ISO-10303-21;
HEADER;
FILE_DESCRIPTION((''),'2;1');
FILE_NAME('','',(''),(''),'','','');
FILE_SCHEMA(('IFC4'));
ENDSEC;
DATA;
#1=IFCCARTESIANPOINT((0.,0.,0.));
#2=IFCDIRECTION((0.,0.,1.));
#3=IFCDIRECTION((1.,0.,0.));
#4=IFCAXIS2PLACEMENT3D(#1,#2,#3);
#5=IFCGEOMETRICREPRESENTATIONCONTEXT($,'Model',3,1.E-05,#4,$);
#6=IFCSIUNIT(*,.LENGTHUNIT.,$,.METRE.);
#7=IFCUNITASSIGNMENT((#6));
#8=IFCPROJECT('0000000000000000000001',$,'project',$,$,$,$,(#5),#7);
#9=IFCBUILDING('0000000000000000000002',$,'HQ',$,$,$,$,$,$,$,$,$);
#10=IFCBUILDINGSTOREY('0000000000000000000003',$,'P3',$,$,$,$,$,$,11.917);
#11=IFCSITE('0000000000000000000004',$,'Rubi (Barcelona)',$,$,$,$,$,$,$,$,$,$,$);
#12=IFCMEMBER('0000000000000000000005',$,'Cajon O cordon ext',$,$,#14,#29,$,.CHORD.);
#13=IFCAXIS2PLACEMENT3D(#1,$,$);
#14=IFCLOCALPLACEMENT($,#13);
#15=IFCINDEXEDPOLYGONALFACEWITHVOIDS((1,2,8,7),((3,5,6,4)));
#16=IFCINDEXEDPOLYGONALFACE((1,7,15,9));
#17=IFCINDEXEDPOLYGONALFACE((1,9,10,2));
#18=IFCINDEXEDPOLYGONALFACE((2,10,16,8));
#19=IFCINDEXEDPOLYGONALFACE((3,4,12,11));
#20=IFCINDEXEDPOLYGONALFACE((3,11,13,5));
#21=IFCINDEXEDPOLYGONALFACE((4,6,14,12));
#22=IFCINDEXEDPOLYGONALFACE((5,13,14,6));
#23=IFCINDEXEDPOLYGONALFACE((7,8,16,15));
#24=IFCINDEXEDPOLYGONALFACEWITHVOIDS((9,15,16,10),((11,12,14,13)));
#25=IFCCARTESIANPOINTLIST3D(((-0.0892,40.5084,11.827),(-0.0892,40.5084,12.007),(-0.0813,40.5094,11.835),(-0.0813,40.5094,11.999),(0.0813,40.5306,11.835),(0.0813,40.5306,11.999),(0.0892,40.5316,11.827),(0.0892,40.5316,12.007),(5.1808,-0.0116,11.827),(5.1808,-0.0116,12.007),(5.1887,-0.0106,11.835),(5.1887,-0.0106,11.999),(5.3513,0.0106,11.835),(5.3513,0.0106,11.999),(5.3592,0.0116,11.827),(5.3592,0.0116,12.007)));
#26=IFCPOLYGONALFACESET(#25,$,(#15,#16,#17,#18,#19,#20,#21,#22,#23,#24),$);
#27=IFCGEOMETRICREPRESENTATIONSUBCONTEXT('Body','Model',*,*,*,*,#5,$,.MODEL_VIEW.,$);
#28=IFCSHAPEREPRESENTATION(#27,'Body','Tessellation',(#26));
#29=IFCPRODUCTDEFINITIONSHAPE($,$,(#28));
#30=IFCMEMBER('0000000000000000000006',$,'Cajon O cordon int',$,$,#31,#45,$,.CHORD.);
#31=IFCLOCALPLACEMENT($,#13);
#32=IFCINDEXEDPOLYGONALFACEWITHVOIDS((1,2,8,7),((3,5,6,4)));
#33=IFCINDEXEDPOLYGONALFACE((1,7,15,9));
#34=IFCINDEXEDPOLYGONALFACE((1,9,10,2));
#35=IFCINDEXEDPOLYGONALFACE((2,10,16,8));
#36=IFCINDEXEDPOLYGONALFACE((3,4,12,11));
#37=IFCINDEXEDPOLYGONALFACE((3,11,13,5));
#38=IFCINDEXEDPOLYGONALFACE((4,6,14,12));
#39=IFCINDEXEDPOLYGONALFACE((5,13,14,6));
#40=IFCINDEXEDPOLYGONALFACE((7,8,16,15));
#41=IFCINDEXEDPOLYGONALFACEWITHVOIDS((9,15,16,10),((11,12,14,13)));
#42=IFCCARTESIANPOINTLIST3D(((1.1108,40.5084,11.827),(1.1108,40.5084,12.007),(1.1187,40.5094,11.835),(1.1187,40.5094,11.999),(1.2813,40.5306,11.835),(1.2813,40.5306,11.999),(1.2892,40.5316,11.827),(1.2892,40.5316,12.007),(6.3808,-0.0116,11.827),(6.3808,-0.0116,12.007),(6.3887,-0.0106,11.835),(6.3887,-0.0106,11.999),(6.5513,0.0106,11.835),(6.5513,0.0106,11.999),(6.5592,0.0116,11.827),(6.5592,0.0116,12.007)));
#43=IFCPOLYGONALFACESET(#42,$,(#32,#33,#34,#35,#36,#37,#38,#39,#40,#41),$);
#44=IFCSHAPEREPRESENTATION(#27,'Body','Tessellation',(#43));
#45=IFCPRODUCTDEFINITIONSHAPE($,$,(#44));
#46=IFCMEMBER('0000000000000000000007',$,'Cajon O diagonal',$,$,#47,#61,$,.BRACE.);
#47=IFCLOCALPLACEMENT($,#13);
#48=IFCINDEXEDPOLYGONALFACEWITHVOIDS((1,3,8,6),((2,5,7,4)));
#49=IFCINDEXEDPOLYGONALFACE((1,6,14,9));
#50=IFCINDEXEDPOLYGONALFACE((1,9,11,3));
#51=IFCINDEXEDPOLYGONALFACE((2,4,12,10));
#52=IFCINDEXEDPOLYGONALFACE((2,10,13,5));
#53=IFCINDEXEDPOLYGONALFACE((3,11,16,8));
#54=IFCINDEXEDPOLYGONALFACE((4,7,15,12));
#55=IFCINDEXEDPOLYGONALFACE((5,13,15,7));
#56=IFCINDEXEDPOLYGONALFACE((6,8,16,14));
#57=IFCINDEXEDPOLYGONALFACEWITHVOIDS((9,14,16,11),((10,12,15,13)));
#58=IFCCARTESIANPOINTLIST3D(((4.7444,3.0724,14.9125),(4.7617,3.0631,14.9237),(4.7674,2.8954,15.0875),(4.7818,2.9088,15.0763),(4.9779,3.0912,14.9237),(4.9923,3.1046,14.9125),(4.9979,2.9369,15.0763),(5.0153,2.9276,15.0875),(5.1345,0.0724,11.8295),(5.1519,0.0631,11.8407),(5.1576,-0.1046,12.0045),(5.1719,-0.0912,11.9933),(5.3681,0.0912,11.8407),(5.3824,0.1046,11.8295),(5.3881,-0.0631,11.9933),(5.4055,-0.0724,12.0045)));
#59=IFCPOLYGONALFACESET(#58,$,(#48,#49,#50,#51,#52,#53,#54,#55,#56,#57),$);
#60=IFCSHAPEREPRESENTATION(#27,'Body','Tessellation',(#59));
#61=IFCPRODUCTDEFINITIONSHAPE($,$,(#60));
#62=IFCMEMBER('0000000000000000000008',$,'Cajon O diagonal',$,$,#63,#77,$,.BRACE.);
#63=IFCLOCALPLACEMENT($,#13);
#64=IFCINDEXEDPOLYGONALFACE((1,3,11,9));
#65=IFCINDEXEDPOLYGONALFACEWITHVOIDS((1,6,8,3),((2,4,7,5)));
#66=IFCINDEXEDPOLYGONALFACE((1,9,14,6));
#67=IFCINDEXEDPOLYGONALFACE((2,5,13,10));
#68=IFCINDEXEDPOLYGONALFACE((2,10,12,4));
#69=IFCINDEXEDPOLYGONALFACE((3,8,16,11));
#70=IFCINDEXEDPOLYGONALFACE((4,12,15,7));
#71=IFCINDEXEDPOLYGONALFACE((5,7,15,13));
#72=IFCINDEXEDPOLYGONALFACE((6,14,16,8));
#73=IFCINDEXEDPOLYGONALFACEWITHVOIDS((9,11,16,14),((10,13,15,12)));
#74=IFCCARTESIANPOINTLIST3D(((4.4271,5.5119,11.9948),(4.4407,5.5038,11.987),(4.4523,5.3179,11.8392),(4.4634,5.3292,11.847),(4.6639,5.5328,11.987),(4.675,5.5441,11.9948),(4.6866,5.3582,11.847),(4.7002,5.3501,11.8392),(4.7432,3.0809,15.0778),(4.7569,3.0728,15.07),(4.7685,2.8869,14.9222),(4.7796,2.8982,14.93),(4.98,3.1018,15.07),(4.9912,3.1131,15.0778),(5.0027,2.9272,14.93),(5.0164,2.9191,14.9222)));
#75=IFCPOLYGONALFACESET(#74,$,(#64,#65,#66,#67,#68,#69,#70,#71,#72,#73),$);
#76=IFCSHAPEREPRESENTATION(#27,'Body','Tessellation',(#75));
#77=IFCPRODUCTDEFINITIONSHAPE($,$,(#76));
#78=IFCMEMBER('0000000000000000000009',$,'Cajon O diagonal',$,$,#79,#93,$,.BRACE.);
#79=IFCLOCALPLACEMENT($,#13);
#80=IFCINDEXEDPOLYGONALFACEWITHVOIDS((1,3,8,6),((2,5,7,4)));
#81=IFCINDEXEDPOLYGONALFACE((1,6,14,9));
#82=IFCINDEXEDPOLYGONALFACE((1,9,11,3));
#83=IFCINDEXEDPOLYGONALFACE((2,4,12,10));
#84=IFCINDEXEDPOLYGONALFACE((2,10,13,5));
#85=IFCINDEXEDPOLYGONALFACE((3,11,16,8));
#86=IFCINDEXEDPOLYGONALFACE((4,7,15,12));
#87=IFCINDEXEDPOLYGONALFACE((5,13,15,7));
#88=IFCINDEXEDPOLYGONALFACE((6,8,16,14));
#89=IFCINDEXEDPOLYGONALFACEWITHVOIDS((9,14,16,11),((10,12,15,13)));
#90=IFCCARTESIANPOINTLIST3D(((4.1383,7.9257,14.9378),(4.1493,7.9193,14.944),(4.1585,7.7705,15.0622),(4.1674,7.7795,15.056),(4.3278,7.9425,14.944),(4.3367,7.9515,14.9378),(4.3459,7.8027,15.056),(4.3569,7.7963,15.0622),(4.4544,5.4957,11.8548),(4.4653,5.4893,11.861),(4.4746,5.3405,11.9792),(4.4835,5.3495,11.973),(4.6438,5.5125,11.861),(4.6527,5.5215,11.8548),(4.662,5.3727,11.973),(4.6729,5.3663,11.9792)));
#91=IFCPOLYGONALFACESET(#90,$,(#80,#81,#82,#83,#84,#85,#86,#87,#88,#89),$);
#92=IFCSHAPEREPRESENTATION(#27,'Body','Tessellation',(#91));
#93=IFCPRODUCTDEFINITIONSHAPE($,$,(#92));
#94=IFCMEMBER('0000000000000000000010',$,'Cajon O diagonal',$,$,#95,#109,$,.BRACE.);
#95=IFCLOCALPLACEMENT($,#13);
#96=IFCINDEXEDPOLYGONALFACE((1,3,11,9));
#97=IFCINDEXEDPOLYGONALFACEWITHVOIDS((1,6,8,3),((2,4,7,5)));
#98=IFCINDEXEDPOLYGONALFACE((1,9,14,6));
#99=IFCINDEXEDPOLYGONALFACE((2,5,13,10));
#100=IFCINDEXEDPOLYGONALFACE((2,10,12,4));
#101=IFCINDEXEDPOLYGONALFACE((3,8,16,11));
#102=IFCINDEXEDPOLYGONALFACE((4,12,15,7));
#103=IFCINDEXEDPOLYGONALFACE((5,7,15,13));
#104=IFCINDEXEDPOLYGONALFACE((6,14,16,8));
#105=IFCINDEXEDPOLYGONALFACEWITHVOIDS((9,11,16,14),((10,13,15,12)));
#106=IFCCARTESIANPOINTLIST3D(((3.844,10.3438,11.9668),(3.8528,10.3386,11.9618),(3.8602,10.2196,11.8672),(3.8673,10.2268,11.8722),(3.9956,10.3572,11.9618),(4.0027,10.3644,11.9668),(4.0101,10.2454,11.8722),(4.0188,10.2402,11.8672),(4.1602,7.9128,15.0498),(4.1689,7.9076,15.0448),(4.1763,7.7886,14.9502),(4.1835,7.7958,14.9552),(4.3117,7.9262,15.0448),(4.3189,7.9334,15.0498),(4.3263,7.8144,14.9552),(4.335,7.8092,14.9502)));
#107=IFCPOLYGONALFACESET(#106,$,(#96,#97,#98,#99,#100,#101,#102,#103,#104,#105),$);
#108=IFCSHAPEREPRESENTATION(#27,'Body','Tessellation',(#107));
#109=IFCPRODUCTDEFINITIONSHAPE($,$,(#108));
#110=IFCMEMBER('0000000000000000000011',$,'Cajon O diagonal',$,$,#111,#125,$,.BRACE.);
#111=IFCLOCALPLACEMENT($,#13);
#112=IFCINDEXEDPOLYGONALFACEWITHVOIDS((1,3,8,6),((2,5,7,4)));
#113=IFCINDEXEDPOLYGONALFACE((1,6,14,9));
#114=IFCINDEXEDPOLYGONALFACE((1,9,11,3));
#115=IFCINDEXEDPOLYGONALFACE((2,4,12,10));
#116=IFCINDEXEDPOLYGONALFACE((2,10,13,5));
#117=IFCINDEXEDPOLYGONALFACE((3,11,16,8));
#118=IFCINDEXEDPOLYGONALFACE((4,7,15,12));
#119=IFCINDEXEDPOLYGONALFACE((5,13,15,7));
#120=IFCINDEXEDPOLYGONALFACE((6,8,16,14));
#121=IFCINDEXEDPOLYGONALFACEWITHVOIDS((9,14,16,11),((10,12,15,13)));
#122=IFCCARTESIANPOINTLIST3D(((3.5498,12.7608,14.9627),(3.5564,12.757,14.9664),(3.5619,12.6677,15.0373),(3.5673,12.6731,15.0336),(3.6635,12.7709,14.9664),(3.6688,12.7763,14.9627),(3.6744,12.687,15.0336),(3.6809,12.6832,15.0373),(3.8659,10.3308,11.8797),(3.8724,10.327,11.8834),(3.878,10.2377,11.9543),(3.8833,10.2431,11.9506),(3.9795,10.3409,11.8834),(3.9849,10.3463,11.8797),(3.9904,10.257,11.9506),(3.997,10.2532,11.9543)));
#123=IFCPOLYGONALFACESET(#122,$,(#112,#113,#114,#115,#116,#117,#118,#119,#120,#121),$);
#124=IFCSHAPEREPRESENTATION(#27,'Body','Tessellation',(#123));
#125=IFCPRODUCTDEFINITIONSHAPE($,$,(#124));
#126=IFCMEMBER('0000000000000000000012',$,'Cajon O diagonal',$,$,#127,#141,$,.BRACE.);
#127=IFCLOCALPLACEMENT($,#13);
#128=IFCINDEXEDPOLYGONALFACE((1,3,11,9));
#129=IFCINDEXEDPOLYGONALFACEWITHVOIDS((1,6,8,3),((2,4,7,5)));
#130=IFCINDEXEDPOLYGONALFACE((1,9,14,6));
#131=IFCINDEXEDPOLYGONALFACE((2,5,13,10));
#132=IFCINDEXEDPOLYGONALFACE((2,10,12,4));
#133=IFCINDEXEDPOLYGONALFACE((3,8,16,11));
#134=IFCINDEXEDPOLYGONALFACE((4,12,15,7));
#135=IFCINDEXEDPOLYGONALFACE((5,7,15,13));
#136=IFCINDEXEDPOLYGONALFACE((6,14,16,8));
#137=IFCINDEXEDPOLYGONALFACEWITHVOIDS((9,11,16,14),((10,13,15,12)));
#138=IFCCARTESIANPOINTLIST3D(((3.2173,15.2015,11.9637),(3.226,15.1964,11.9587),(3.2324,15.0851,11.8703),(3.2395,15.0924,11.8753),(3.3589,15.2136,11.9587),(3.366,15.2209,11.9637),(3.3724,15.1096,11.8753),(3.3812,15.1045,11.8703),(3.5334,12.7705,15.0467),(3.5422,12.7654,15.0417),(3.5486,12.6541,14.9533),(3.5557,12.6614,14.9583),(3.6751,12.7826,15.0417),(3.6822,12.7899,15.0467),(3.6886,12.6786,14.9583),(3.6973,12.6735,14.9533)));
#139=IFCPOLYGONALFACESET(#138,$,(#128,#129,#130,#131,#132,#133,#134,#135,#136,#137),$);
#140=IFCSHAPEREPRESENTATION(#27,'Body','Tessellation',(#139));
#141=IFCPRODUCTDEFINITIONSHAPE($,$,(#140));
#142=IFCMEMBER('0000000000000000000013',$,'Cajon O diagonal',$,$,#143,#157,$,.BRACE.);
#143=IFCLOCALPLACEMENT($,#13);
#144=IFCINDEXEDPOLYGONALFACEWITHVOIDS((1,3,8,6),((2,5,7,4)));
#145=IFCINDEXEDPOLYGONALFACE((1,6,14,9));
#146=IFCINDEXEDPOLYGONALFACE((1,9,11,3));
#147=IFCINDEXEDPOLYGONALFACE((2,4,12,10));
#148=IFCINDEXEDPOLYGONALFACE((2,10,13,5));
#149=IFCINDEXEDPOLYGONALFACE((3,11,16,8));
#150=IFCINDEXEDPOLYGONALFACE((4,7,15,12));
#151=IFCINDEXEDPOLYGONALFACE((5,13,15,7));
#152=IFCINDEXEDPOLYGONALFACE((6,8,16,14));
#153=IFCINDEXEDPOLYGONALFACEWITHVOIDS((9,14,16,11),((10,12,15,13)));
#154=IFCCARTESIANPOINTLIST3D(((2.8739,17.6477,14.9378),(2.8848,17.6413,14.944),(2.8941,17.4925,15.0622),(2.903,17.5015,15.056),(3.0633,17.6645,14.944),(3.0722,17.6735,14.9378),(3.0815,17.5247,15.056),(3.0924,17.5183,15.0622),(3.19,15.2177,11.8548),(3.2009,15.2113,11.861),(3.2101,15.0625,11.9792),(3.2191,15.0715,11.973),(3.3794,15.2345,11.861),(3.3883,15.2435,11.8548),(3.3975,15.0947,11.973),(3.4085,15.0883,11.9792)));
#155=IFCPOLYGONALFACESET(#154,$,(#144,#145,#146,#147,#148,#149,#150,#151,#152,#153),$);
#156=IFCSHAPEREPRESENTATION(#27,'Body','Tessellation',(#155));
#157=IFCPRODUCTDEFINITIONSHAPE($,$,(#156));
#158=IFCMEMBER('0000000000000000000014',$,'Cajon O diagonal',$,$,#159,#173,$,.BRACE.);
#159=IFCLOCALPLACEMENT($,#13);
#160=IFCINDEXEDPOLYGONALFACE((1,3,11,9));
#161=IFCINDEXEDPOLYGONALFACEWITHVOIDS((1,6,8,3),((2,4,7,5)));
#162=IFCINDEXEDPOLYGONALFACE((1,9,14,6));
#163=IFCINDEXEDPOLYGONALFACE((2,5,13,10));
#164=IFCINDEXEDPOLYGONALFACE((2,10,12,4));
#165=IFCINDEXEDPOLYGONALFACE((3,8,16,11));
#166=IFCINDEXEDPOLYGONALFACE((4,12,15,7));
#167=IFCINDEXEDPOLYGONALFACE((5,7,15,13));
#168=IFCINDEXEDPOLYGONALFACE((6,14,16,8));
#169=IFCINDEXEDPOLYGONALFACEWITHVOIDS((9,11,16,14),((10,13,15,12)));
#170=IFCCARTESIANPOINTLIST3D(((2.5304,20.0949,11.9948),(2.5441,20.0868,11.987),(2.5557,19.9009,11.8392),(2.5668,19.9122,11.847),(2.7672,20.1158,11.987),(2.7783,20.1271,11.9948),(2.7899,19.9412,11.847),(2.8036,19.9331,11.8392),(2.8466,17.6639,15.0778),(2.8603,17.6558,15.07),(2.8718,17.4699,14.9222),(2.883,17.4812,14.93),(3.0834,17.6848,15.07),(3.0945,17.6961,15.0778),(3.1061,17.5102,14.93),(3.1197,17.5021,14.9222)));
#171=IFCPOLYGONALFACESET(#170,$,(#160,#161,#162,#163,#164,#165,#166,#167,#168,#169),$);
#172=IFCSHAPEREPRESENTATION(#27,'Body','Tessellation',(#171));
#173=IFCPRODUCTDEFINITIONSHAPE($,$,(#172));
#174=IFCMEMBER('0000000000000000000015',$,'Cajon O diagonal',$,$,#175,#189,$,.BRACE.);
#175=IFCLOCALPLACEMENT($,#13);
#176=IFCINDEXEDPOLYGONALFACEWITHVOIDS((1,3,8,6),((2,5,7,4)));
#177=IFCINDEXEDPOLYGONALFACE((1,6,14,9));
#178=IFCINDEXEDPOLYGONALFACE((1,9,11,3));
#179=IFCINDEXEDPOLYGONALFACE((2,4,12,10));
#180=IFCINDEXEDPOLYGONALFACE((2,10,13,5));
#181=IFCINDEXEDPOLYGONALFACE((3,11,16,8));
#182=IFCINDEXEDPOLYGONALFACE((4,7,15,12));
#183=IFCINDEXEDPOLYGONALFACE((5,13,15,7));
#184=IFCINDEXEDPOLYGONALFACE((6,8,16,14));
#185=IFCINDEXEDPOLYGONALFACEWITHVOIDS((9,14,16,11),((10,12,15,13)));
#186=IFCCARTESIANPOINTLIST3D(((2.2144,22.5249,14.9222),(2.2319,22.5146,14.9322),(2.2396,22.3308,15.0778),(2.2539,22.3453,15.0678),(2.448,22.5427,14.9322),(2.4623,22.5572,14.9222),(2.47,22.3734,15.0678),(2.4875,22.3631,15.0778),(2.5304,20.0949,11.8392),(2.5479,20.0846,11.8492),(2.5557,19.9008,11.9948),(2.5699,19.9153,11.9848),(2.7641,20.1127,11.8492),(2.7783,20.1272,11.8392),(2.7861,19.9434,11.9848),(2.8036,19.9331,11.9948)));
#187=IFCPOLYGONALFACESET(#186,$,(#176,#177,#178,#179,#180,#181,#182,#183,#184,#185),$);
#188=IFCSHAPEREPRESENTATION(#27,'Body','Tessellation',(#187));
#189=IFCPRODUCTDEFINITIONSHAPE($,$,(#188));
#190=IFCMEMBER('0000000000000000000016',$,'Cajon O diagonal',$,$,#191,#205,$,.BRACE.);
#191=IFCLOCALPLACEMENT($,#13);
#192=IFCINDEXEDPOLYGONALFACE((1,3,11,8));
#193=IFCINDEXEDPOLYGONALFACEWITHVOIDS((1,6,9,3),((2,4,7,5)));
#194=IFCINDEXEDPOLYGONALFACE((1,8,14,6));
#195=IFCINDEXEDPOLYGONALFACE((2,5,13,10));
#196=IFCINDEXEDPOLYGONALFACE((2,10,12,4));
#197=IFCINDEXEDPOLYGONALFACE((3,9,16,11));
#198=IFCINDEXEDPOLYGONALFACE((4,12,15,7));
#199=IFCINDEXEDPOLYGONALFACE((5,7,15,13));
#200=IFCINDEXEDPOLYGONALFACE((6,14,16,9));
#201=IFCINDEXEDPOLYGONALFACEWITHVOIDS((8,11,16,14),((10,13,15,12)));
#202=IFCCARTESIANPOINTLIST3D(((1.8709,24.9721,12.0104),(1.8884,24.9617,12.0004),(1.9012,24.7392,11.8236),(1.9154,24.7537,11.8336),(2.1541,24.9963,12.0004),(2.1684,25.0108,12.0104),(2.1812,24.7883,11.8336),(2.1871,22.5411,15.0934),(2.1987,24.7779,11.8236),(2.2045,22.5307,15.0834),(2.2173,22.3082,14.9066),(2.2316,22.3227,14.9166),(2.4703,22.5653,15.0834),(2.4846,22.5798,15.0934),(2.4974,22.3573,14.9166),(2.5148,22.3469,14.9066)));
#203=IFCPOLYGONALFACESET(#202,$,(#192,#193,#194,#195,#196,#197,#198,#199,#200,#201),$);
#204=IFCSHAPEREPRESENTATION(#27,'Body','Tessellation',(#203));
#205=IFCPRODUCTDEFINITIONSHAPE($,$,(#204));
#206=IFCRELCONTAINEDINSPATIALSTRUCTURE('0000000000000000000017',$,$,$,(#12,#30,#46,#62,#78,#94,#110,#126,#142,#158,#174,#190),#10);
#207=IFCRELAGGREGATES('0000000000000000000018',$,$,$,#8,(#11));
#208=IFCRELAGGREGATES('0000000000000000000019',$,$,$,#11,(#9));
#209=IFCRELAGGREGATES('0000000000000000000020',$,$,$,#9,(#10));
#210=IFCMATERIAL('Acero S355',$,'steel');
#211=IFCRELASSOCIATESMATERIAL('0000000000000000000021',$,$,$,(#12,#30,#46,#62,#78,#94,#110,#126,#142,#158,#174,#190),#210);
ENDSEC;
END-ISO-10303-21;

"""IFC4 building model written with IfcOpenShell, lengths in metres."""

from ifc_helpers import new_model, si_unit, frame, origin_with_axes, place, context, subcontext, project, spatial, hollow_rectangle, extrude, material, element, save


model = new_model("IFC4")

# Units and contexts
model_context = context("Model", 3, precision=1e-05, world=origin_with_axes())
body_context = subcontext(model_context, "Body", "Model", "MODEL_VIEW")
ifc_project = project(units=[si_unit("LENGTHUNIT", "METRE")], contexts=[model_context])

# Site, building, storey
site = spatial("IfcSite", under=ifc_project, Name="Rubi (Barcelona)")
building = spatial("IfcBuilding", under=site, Name="HQ")
storey = spatial("IfcBuildingStorey", under=building, Name="P3", Elevation=11.917)

# Members
ifc_material = material(Name="Acero S355", Category="steel")
member_1_placement = place(None, origin_with_axes())
element("IfcMember", 1, at=member_1_placement, inside=storey, material=ifc_material, Name="Cajon O cordon ext", PredefinedType="CHORD", context=body_context, shape_type="SweptSolid", body=[
    extrude(hollow_rectangle(XDim=0.18, YDim=0.18, WallThickness=0.008), frame((5.27, 0.0, 11.917), z_axis=(-0.128973, 0.991648, 0.0), x_axis=(-0.991648, -0.128973, 0.0)), (0.0, 0.0, 1.0), 40.8613),
])
member_2_placement = place(None, origin_with_axes())
element("IfcMember", 2, at=member_2_placement, inside=storey, material=ifc_material, Name="Cajon O cordon int", PredefinedType="CHORD", context=body_context, shape_type="SweptSolid", body=[
    extrude(hollow_rectangle(XDim=0.18, YDim=0.18, WallThickness=0.008), frame((6.47, 0.0, 11.917), z_axis=(-0.128973, 0.991648, 0.0), x_axis=(-0.991648, -0.128973, 0.0)), (0.0, 0.0, 1.0), 40.8613),
])
member_3_placement = place(None, origin_with_axes())
element("IfcMember", 3, at=member_3_placement, inside=storey, material=ifc_material, Name="Cajon O diagonal", PredefinedType="BRACE", context=body_context, shape_type="SweptSolid", body=[
    extrude(hollow_rectangle(XDim=0.25, YDim=0.25, WallThickness=0.016), frame((5.27, 0.0, 11.917), z_axis=(-0.090332, 0.694543, 0.713758), x_axis=(-0.991648, -0.128973, 0.0)), (0.0, 0.0, 1.0), 4.3194),
])
member_4_placement = place(None, origin_with_axes())
element("IfcMember", 4, at=member_4_placement, inside=storey, material=ifc_material, Name="Cajon O diagonal", PredefinedType="BRACE", context=body_context, shape_type="SweptSolid", body=[
    extrude(hollow_rectangle(XDim=0.25, YDim=0.25, WallThickness=0.0125), frame((4.5636, 5.431, 11.917), z_axis=(0.08027, -0.617184, 0.782714), x_axis=(0.991648, 0.128973, 0.0)), (0.0, 0.0, 1.0), 3.9389),
])
member_5_placement = place(None, origin_with_axes())
element("IfcMember", 5, at=member_5_placement, inside=storey, material=ifc_material, Name="Cajon O diagonal", PredefinedType="BRACE", context=body_context, shape_type="SweptSolid", body=[
    extrude(hollow_rectangle(XDim=0.2, YDim=0.2, WallThickness=0.01), frame((4.5636, 5.431, 11.917), z_axis=(-0.08025, 0.617028, 0.782839), x_axis=(-0.991648, -0.128973, 0.0)), (0.0, 0.0, 1.0), 3.9382),
])
member_6_placement = place(None, origin_with_axes())
element("IfcMember", 6, at=member_6_placement, inside=storey, material=ifc_material, Name="Cajon O diagonal", PredefinedType="BRACE", context=body_context, shape_type="SweptSolid", body=[
    extrude(hollow_rectangle(XDim=0.16, YDim=0.16, WallThickness=0.008), frame((3.9314, 10.292, 11.917), z_axis=(0.08027, -0.617184, 0.782714), x_axis=(0.991648, 0.128973, 0.0)), (0.0, 0.0, 1.0), 3.9389),
])
member_7_placement = place(None, origin_with_axes())
element("IfcMember", 7, at=member_7_placement, inside=storey, material=ifc_material, Name="Cajon O diagonal", PredefinedType="BRACE", context=body_context, shape_type="SweptSolid", body=[
    extrude(hollow_rectangle(XDim=0.12, YDim=0.12, WallThickness=0.006), frame((3.9314, 10.292, 11.917), z_axis=(-0.08025, 0.617028, 0.782839), x_axis=(-0.991648, -0.128973, 0.0)), (0.0, 0.0, 1.0), 3.9382),
])
member_8_placement = place(None, origin_with_axes())
element("IfcMember", 8, at=member_8_placement, inside=storey, material=ifc_material, Name="Cajon O diagonal", PredefinedType="BRACE", context=body_context, shape_type="SweptSolid", body=[
    extrude(hollow_rectangle(XDim=0.15, YDim=0.15, WallThickness=0.008), frame((3.2992, 15.153, 11.917), z_axis=(0.08027, -0.617184, 0.782714), x_axis=(0.991648, 0.128973, 0.0)), (0.0, 0.0, 1.0), 3.9389),
])
member_9_placement = place(None, origin_with_axes())
element("IfcMember", 9, at=member_9_placement, inside=storey, material=ifc_material, Name="Cajon O diagonal", PredefinedType="BRACE", context=body_context, shape_type="SweptSolid", body=[
    extrude(hollow_rectangle(XDim=0.2, YDim=0.2, WallThickness=0.01), frame((3.2992, 15.153, 11.917), z_axis=(-0.08025, 0.617028, 0.782839), x_axis=(-0.991648, -0.128973, 0.0)), (0.0, 0.0, 1.0), 3.9382),
])
member_10_placement = place(None, origin_with_axes())
element("IfcMember", 10, at=member_10_placement, inside=storey, material=ifc_material, Name="Cajon O diagonal", PredefinedType="BRACE", context=body_context, shape_type="SweptSolid", body=[
    extrude(hollow_rectangle(XDim=0.25, YDim=0.25, WallThickness=0.0125), frame((2.667, 20.014, 11.917), z_axis=(0.08027, -0.617184, 0.782714), x_axis=(0.991648, 0.128973, 0.0)), (0.0, 0.0, 1.0), 3.9389),
])
member_11_placement = place(None, origin_with_axes())
element("IfcMember", 11, at=member_11_placement, inside=storey, material=ifc_material, Name="Cajon O diagonal", PredefinedType="BRACE", context=body_context, shape_type="SweptSolid", body=[
    extrude(hollow_rectangle(XDim=0.25, YDim=0.25, WallThickness=0.016), frame((2.667, 20.014, 11.917), z_axis=(-0.08025, 0.617028, 0.782839), x_axis=(-0.991648, -0.128973, 0.0)), (0.0, 0.0, 1.0), 3.9382),
])
member_12_placement = place(None, origin_with_axes())
element("IfcMember", 12, at=member_12_placement, inside=storey, material=ifc_material, Name="Cajon O diagonal", PredefinedType="BRACE", context=body_context, shape_type="SweptSolid", body=[
    extrude(hollow_rectangle(XDim=0.3, YDim=0.3, WallThickness=0.016), frame((2.0348, 24.875, 11.917), z_axis=(0.08027, -0.617184, 0.782714), x_axis=(0.991648, 0.128973, 0.0)), (0.0, 0.0, 1.0), 3.9389),
])

save(model, "model.ifc")
